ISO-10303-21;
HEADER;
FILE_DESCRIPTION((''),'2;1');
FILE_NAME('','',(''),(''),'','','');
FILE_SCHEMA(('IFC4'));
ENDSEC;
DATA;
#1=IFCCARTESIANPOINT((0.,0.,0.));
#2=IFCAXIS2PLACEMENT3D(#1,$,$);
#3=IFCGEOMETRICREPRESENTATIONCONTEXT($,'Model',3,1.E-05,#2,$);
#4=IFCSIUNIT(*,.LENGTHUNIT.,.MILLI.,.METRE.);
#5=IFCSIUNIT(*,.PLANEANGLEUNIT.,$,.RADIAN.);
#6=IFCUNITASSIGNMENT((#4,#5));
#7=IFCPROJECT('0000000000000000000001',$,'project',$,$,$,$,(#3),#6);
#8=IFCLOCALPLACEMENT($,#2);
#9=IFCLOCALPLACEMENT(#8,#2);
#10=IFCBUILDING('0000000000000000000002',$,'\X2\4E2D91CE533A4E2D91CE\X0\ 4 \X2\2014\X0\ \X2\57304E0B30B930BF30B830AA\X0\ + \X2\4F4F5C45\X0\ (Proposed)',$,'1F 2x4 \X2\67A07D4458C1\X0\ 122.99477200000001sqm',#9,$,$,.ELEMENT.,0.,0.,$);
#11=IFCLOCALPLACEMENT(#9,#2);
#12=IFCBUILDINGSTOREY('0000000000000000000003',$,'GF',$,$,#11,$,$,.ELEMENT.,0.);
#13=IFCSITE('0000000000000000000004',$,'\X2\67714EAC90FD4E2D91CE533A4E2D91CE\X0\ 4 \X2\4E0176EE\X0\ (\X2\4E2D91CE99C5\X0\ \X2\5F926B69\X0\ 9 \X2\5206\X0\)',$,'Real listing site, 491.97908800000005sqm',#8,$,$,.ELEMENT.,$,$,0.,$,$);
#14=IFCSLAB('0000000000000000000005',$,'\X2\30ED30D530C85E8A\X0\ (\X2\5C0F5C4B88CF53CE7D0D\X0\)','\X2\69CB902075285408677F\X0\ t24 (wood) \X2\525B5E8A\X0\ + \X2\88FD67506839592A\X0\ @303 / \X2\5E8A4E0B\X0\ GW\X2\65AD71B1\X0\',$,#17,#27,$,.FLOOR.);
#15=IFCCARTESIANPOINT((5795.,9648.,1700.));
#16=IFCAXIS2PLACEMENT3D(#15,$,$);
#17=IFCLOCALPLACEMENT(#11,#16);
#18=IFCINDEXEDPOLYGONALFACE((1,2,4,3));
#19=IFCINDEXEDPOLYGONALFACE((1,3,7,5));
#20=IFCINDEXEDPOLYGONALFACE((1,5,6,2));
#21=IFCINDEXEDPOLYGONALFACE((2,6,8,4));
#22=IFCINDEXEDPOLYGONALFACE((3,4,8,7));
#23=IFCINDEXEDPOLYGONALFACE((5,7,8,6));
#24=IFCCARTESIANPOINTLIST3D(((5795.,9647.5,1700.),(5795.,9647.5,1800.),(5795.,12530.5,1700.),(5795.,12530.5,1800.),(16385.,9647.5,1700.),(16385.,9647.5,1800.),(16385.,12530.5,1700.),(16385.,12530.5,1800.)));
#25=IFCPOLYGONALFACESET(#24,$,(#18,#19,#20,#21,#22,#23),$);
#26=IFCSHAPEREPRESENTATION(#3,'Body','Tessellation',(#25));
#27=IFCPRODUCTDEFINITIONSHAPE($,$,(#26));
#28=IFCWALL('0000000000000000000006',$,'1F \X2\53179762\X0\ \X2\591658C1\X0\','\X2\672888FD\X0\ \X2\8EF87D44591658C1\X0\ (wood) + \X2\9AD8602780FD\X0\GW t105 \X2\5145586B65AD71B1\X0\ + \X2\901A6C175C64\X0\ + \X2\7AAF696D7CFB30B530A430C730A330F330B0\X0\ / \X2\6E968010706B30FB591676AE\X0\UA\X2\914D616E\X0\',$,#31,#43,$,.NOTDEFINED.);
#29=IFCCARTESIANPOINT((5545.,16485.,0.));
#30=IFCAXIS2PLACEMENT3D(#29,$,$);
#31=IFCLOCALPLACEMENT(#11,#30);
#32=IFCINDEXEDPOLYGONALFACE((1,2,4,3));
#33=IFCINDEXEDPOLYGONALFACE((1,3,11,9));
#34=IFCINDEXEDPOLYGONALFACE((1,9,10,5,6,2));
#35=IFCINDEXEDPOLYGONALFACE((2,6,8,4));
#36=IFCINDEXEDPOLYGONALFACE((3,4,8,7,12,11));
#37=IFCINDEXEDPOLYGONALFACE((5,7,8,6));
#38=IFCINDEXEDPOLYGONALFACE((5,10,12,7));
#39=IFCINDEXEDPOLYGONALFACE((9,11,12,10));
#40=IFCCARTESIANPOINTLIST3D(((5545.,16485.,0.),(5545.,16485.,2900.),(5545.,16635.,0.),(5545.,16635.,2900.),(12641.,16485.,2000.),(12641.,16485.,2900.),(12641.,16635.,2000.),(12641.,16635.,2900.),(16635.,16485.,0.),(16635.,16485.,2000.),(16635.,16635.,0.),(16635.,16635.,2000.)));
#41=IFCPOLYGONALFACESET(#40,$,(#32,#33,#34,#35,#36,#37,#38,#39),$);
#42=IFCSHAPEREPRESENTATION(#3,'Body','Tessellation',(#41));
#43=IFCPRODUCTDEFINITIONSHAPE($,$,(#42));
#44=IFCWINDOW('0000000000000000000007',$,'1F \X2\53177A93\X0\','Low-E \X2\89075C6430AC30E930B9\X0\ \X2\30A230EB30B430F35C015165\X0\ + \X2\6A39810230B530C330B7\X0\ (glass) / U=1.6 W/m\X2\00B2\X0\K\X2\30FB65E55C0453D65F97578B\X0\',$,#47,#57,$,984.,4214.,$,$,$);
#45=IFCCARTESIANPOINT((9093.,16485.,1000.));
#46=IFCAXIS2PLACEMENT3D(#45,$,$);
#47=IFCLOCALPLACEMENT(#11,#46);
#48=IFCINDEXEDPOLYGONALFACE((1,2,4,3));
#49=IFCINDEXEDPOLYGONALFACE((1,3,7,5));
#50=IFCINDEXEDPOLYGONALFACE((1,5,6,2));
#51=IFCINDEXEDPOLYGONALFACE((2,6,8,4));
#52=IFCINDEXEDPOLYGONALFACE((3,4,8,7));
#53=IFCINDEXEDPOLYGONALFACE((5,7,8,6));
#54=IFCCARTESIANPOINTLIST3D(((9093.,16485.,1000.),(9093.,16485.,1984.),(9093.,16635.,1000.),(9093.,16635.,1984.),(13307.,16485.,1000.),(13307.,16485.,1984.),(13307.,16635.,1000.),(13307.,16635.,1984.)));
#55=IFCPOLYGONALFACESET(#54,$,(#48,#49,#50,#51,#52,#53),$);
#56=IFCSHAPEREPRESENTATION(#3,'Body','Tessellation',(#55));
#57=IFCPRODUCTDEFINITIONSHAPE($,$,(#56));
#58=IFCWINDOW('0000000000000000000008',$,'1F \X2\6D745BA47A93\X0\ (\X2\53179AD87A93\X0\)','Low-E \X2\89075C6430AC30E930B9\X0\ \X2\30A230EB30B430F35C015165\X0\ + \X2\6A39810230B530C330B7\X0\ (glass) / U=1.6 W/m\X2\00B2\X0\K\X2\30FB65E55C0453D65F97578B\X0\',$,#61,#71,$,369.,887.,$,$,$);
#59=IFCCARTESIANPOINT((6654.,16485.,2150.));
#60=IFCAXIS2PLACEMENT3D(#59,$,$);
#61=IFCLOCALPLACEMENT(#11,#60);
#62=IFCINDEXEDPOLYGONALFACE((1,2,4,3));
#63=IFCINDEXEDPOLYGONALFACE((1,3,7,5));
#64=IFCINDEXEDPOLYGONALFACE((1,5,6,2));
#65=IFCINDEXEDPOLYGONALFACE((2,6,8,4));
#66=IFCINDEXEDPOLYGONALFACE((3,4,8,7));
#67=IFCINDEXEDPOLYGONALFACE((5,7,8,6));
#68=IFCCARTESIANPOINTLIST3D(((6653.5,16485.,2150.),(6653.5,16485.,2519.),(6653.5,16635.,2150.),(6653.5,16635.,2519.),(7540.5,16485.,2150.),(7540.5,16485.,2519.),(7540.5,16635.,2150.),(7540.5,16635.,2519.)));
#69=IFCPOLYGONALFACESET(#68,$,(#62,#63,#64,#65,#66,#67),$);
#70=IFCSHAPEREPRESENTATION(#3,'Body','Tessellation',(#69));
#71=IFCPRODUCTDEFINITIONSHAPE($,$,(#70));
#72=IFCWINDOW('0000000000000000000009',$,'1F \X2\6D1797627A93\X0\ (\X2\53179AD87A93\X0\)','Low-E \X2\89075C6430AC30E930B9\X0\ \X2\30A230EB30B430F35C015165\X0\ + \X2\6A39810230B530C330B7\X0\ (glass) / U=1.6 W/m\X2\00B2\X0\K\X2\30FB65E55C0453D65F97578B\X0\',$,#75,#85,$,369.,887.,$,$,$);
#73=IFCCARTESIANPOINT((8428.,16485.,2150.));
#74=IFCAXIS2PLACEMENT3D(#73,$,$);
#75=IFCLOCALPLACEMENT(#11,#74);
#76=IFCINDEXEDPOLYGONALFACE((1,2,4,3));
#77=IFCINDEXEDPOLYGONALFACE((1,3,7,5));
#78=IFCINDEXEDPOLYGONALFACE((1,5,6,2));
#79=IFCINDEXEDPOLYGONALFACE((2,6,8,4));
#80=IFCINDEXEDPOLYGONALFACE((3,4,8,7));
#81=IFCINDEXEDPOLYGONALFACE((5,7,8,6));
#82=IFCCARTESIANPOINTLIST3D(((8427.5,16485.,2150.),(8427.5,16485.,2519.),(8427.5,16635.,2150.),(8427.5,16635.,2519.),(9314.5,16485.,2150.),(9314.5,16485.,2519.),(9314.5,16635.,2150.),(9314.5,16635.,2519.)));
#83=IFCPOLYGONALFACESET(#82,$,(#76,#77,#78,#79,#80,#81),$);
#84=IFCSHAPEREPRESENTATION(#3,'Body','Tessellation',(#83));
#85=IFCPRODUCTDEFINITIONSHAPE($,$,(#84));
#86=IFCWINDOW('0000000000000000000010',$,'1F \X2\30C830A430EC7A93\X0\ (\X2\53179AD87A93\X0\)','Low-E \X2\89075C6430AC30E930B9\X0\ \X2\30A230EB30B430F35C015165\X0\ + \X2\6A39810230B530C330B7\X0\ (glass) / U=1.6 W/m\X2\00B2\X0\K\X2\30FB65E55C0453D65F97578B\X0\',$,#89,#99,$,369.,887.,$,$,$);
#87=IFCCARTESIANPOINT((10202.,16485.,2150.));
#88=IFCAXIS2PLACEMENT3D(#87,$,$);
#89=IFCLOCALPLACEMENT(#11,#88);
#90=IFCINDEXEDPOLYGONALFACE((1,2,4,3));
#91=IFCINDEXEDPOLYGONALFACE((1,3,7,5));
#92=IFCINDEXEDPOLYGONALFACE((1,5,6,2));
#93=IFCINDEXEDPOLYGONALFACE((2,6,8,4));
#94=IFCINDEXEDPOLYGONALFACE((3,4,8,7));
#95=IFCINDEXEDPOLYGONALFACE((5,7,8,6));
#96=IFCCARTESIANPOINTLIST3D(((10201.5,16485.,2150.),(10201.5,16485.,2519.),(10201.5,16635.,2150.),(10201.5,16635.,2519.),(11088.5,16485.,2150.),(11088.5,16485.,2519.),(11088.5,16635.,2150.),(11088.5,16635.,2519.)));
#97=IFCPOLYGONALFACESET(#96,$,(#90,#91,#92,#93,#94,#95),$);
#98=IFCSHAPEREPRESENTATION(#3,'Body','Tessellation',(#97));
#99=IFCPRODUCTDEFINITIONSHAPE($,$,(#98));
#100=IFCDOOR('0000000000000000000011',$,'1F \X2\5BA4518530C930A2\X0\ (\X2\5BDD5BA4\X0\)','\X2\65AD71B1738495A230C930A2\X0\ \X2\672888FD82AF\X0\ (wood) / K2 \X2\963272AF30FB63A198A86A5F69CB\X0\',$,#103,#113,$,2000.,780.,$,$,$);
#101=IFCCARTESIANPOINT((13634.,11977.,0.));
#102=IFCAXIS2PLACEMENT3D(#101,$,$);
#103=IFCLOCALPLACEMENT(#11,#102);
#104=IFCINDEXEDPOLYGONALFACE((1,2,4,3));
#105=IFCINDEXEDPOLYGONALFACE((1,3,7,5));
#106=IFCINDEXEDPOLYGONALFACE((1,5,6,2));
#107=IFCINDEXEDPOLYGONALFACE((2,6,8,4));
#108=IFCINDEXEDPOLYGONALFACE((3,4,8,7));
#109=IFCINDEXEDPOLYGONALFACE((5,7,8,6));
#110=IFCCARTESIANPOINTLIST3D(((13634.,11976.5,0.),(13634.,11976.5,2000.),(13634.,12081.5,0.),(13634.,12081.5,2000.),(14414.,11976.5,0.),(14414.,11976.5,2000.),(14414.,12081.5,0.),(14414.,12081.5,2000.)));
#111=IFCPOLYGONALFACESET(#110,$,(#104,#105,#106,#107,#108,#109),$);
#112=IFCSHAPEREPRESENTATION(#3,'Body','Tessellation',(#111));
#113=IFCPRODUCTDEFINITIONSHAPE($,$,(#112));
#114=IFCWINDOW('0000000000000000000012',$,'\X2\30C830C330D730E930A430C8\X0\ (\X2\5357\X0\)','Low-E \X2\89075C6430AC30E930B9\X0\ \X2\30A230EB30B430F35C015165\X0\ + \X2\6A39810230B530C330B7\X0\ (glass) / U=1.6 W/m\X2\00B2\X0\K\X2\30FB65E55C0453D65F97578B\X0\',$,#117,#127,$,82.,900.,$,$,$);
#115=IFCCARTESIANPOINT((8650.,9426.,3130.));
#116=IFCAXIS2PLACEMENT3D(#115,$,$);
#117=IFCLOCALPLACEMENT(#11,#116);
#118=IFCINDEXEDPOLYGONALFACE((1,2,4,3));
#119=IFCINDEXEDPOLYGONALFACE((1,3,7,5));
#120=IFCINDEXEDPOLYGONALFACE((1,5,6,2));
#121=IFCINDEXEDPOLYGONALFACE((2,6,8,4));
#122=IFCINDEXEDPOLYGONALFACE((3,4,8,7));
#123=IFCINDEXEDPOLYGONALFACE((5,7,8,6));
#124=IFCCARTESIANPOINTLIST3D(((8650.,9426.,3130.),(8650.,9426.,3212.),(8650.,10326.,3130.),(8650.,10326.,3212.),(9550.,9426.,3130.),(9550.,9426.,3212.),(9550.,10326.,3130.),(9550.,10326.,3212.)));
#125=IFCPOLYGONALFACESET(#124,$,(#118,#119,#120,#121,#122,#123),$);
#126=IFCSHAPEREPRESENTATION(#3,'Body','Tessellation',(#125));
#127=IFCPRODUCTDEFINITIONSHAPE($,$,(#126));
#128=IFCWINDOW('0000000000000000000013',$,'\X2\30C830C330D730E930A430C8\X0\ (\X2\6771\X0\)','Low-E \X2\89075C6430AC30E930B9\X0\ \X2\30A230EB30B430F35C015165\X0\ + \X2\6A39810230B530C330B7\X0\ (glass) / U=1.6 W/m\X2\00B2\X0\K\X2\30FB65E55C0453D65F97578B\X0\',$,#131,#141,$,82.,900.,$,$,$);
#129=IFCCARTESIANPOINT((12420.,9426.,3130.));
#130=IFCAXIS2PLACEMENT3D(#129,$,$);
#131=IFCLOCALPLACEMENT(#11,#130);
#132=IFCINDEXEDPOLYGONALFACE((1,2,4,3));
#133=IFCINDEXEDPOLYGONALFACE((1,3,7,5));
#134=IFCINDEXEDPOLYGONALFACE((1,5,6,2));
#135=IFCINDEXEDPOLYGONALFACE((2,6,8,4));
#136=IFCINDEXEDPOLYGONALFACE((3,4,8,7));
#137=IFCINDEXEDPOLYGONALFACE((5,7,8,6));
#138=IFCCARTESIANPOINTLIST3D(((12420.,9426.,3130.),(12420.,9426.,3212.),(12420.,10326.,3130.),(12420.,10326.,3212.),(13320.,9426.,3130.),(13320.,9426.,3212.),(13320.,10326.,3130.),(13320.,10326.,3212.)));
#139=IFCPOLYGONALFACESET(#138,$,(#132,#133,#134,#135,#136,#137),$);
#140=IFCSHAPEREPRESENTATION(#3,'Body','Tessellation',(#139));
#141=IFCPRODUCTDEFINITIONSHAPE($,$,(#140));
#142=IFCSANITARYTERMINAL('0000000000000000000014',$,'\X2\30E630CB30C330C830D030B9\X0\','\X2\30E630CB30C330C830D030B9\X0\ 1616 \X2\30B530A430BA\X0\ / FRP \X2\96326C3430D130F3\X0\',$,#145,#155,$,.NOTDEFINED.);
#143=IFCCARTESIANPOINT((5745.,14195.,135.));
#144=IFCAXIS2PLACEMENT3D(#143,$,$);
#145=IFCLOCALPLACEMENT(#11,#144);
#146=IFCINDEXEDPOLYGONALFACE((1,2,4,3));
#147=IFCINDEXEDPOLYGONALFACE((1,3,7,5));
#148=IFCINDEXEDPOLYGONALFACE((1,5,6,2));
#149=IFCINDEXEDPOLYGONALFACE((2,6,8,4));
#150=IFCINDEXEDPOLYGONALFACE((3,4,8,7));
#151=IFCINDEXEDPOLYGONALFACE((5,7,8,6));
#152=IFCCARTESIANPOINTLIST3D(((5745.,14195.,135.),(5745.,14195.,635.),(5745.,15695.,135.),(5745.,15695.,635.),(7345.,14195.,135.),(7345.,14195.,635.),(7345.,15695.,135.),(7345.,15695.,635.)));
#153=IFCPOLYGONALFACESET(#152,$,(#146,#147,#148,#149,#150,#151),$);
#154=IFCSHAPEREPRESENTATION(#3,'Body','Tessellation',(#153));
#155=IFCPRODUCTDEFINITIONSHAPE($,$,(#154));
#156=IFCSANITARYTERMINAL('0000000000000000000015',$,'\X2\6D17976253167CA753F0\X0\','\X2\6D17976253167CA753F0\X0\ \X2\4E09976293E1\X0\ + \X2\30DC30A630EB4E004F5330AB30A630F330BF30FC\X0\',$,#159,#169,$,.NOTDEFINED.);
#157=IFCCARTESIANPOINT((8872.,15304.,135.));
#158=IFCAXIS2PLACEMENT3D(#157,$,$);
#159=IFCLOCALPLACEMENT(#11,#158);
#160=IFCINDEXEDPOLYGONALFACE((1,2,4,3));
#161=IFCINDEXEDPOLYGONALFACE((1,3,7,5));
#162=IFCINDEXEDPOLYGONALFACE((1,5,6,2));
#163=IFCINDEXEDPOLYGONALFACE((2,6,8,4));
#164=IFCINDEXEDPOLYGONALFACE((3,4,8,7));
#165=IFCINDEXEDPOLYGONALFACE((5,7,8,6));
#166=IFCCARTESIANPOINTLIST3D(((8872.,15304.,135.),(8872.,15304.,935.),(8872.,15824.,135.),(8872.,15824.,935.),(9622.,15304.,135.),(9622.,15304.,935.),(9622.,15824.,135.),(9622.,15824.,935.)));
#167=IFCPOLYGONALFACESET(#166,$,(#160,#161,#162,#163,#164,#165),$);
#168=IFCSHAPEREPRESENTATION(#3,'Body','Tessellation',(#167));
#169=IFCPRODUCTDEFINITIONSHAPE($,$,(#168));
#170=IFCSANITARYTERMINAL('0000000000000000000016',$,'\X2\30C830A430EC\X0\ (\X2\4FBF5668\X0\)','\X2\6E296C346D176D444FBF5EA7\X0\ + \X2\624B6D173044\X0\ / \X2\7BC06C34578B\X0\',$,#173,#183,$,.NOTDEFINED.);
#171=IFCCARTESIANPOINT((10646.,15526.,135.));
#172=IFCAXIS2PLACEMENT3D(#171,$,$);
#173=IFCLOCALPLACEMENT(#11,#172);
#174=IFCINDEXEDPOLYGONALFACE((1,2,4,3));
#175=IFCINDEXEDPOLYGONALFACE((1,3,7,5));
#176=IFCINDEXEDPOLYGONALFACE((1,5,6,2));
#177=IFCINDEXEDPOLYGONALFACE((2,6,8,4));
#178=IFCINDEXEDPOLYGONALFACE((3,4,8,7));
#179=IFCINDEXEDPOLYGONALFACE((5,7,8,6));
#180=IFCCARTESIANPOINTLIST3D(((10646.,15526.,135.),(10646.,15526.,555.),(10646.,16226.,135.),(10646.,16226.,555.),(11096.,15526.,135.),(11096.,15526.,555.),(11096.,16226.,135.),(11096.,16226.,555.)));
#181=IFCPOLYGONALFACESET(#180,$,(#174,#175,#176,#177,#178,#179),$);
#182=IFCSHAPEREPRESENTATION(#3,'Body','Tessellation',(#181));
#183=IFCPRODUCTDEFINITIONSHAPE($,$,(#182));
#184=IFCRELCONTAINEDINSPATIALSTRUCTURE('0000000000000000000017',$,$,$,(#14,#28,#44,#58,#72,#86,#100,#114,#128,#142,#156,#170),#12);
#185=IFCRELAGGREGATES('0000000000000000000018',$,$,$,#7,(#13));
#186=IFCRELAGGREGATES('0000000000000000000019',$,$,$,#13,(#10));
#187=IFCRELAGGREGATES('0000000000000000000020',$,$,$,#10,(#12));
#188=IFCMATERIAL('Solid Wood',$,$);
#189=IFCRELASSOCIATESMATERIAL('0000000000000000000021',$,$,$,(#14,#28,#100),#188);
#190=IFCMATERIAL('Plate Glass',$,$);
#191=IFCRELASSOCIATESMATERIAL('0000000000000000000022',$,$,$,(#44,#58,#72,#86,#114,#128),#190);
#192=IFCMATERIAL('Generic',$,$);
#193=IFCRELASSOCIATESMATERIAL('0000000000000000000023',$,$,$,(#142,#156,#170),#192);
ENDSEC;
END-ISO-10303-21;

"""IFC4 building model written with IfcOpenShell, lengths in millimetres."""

from ifc_helpers import new_model, si_unit, frame, frame_2d, origin, place, context, project, spatial, rectangle, extrude, material, element, fill, save


model = new_model("IFC4")

# Units and contexts
model_context = context("Model", 3, precision=1e-05, world=origin())
ifc_project = project(units=[si_unit("LENGTHUNIT", "METRE", prefix="MILLI"), si_unit("PLANEANGLEUNIT", "RADIAN")], contexts=[model_context])

# Site, building, storey
site_placement = place(None, origin())
site = spatial("IfcSite", under=ifc_project, at=site_placement, Name="東京都中野区中野 4 丁目 (中野駅 徒歩 9 分)", ObjectType="Real listing site, 491.97908800000005sqm", CompositionType="ELEMENT", RefElevation=0.0)
building_placement = place(site_placement, origin())
building = spatial("IfcBuilding", under=site, at=building_placement, Name="中野区中野 4 — 地下スタジオ + 住居 (Proposed)", ObjectType="1F 2x4 枠組壁 122.99477200000001sqm", CompositionType="ELEMENT", ElevationOfRefHeight=0.0, ElevationOfTerrain=0.0)
storey_placement = place(building_placement, origin())
storey = spatial("IfcBuildingStorey", under=building, at=storey_placement, Name="GF", CompositionType="ELEMENT", Elevation=0.0)

# Slab
ifc_material_1 = material(Name="Solid Wood")
slab_placement = place(storey_placement, frame((5795.0, 9648.0, 1700.0)))
element("IfcSlab", 1, at=slab_placement, inside=storey, material=ifc_material_1, Name="ロフト床 (小屋裏収納)", Description="構造用合板 t24 (wood) 剛床 + 製材根太 @303 / 床下 GW断熱", PredefinedType="FLOOR", context=model_context, shape_type="SweptSolid", body=[
    extrude(rectangle(XDim=10590.0, YDim=2883.0, at=frame_2d((5295.0, 1441.0))), frame((5795.0, 9648.0, 1700.0)), (0.0, 0.0, 1.0), 100.0),
])

# Wall, openings, windows
wall_1_placement = place(storey_placement, frame((5545.0, 16485.0, 0.0)))
wall_1 = element("IfcWall", 2, at=wall_1_placement, inside=storey, material=ifc_material_1, Name="1F 北面 外壁", Description="木製 軸組外壁 (wood) + 高性能GW t105 充填断熱 + 通気層 + 窯業系サイディング / 準耐火・外皮UA配慮", PredefinedType="NOTDEFINED", context=model_context, shape_type="SweptSolid", body=[
    extrude(rectangle(XDim=11090.0, YDim=150.0, at=frame_2d((5545.0, 75.0))), frame((5545.0, 16485.0, 0.0)), (0.0, 0.0, 1.0), 2900.0),
])
opening_1_placement = place(storey_placement, frame((9093.0, 16485.0, 1000.0)))
opening_1 = element("IfcOpeningElement", 3, at=opening_1_placement, cuts=wall_1, PredefinedType="NOTDEFINED", context=model_context, shape_type="SweptSolid", body=[
    extrude(rectangle(XDim=4214.0, YDim=150.0, at=frame_2d((2107.0, 75.0))), frame((9093.0, 16485.0, 1000.0)), (0.0, 0.0, 1.0), 984.0),
])
opening_2_placement = place(storey_placement, frame((6654.0, 16485.0, 2150.0)))
opening_2 = element("IfcOpeningElement", 4, at=opening_2_placement, cuts=wall_1, PredefinedType="NOTDEFINED", context=model_context, shape_type="SweptSolid", body=[
    extrude(rectangle(XDim=887.0, YDim=150.0, at=frame_2d((443.0, 75.0))), frame((6654.0, 16485.0, 2150.0)), (0.0, 0.0, 1.0), 369.0),
])
opening_3_placement = place(storey_placement, frame((8428.0, 16485.0, 2150.0)))
opening_3 = element("IfcOpeningElement", 5, at=opening_3_placement, cuts=wall_1, PredefinedType="NOTDEFINED", context=model_context, shape_type="SweptSolid", body=[
    extrude(rectangle(XDim=887.0, YDim=150.0, at=frame_2d((443.0, 75.0))), frame((8428.0, 16485.0, 2150.0)), (0.0, 0.0, 1.0), 369.0),
])
opening_4_placement = place(storey_placement, frame((10202.0, 16485.0, 2150.0)))
opening_4 = element("IfcOpeningElement", 6, at=opening_4_placement, cuts=wall_1, PredefinedType="NOTDEFINED", context=model_context, shape_type="SweptSolid", body=[
    extrude(rectangle(XDim=887.0, YDim=150.0, at=frame_2d((443.0, 75.0))), frame((10202.0, 16485.0, 2150.0)), (0.0, 0.0, 1.0), 369.0),
])
ifc_material_2 = material(Name="Plate Glass")
window_1_placement = place(storey_placement, frame((9093.0, 16485.0, 1000.0)))
window_1 = element("IfcWindow", 7, at=window_1_placement, inside=storey, material=ifc_material_2, Name="1F 北窓", Description="Low-E 複層ガラス アルゴン封入 + 樹脂サッシ (glass) / U=1.6 W/m²K・日射取得型", OverallHeight=984.0, OverallWidth=4214.0, context=model_context, shape_type="SweptSolid", body=[
    extrude(rectangle(XDim=4214.0, YDim=150.0, at=frame_2d((2107.0, 75.0))), frame((9093.0, 16485.0, 1000.0)), (0.0, 0.0, 1.0), 984.0),
])
fill(opening_1, window_1)
window_2_placement = place(storey_placement, frame((6654.0, 16485.0, 2150.0)))
window_2 = element("IfcWindow", 8, at=window_2_placement, inside=storey, material=ifc_material_2, Name="1F 浴室窓 (北高窓)", Description="Low-E 複層ガラス アルゴン封入 + 樹脂サッシ (glass) / U=1.6 W/m²K・日射取得型", OverallHeight=369.0, OverallWidth=887.0, context=model_context, shape_type="SweptSolid", body=[
    extrude(rectangle(XDim=887.0, YDim=150.0, at=frame_2d((443.0, 75.0))), frame((6654.0, 16485.0, 2150.0)), (0.0, 0.0, 1.0), 369.0),
])
fill(opening_2, window_2)
window_3_placement = place(storey_placement, frame((8428.0, 16485.0, 2150.0)))
window_3 = element("IfcWindow", 9, at=window_3_placement, inside=storey, material=ifc_material_2, Name="1F 洗面窓 (北高窓)", Description="Low-E 複層ガラス アルゴン封入 + 樹脂サッシ (glass) / U=1.6 W/m²K・日射取得型", OverallHeight=369.0, OverallWidth=887.0, context=model_context, shape_type="SweptSolid", body=[
    extrude(rectangle(XDim=887.0, YDim=150.0, at=frame_2d((443.0, 75.0))), frame((8428.0, 16485.0, 2150.0)), (0.0, 0.0, 1.0), 369.0),
])
fill(opening_3, window_3)
window_4_placement = place(storey_placement, frame((10202.0, 16485.0, 2150.0)))
window_4 = element("IfcWindow", 10, at=window_4_placement, inside=storey, material=ifc_material_2, Name="1F トイレ窓 (北高窓)", Description="Low-E 複層ガラス アルゴン封入 + 樹脂サッシ (glass) / U=1.6 W/m²K・日射取得型", OverallHeight=369.0, OverallWidth=887.0, context=model_context, shape_type="SweptSolid", body=[
    extrude(rectangle(XDim=887.0, YDim=150.0, at=frame_2d((443.0, 75.0))), frame((10202.0, 16485.0, 2150.0)), (0.0, 0.0, 1.0), 369.0),
])
fill(opening_4, window_4)

# Door
door_1_placement = place(storey_placement, frame((13634.0, 11977.0, 0.0)))
element("IfcDoor", 11, at=door_1_placement, inside=storey, material=ifc_material_1, Name="1F 室内ドア (寝室)", Description="断熱玄関ドア 木製芯 (wood) / K2 防犯・採風機構", OverallHeight=2000.0, OverallWidth=780.0, context=model_context, shape_type="SweptSolid", body=[
    extrude(rectangle(XDim=780.0, YDim=105.0, at=frame_2d((390.0, 52.0))), frame((13634.0, 11977.0, 0.0)), (0.0, 0.0, 1.0), 2000.0),
])

# Windows
window_5_placement = place(storey_placement, frame((8650.0, 9426.0, 3130.0)))
element("IfcWindow", 12, at=window_5_placement, inside=storey, material=ifc_material_2, Name="トップライト (南)", Description="Low-E 複層ガラス アルゴン封入 + 樹脂サッシ (glass) / U=1.6 W/m²K・日射取得型", OverallHeight=82.0, OverallWidth=900.0, context=model_context, shape_type="SweptSolid", body=[
    extrude(rectangle(XDim=900.0, YDim=900.0, at=frame_2d((450.0, 450.0))), frame((8650.0, 9426.0, 3130.0)), (0.0, 0.0, 1.0), 82.0),
])
window_6_placement = place(storey_placement, frame((12420.0, 9426.0, 3130.0)))
element("IfcWindow", 13, at=window_6_placement, inside=storey, material=ifc_material_2, Name="トップライト (東)", Description="Low-E 複層ガラス アルゴン封入 + 樹脂サッシ (glass) / U=1.6 W/m²K・日射取得型", OverallHeight=82.0, OverallWidth=900.0, context=model_context, shape_type="SweptSolid", body=[
    extrude(rectangle(XDim=900.0, YDim=900.0, at=frame_2d((450.0, 450.0))), frame((12420.0, 9426.0, 3130.0)), (0.0, 0.0, 1.0), 82.0),
])

# Sanitary terminals
ifc_material_3 = material(Name="Generic")
sanitary_terminal_1_placement = place(storey_placement, frame((5745.0, 14195.0, 135.0)))
element("IfcSanitaryTerminal", 14, at=sanitary_terminal_1_placement, inside=storey, material=ifc_material_3, Name="ユニットバス", Description="ユニットバス 1616 サイズ / FRP 防水パン", PredefinedType="NOTDEFINED", context=model_context, shape_type="SweptSolid", body=[
    extrude(rectangle(XDim=1600.0, YDim=1500.0, at=frame_2d((800.0, 750.0))), frame((5745.0, 14195.0, 135.0)), (0.0, 0.0, 1.0), 500.0),
])
sanitary_terminal_2_placement = place(storey_placement, frame((8872.0, 15304.0, 135.0)))
element("IfcSanitaryTerminal", 15, at=sanitary_terminal_2_placement, inside=storey, material=ifc_material_3, Name="洗面化粧台", Description="洗面化粧台 三面鏡 + ボウル一体カウンター", PredefinedType="NOTDEFINED", context=model_context, shape_type="SweptSolid", body=[
    extrude(rectangle(XDim=750.0, YDim=520.0, at=frame_2d((375.0, 260.0))), frame((8872.0, 15304.0, 135.0)), (0.0, 0.0, 1.0), 800.0),
])
sanitary_terminal_3_placement = place(storey_placement, frame((10646.0, 15526.0, 135.0)))
element("IfcSanitaryTerminal", 16, at=sanitary_terminal_3_placement, inside=storey, material=ifc_material_3, Name="トイレ (便器)", Description="温水洗浄便座 + 手洗い / 節水型", PredefinedType="NOTDEFINED", context=model_context, shape_type="SweptSolid", body=[
    extrude(rectangle(XDim=450.0, YDim=700.0, at=frame_2d((225.0, 350.0))), frame((10646.0, 15526.0, 135.0)), (0.0, 0.0, 1.0), 420.0),
])

save(model, "model.ifc")
